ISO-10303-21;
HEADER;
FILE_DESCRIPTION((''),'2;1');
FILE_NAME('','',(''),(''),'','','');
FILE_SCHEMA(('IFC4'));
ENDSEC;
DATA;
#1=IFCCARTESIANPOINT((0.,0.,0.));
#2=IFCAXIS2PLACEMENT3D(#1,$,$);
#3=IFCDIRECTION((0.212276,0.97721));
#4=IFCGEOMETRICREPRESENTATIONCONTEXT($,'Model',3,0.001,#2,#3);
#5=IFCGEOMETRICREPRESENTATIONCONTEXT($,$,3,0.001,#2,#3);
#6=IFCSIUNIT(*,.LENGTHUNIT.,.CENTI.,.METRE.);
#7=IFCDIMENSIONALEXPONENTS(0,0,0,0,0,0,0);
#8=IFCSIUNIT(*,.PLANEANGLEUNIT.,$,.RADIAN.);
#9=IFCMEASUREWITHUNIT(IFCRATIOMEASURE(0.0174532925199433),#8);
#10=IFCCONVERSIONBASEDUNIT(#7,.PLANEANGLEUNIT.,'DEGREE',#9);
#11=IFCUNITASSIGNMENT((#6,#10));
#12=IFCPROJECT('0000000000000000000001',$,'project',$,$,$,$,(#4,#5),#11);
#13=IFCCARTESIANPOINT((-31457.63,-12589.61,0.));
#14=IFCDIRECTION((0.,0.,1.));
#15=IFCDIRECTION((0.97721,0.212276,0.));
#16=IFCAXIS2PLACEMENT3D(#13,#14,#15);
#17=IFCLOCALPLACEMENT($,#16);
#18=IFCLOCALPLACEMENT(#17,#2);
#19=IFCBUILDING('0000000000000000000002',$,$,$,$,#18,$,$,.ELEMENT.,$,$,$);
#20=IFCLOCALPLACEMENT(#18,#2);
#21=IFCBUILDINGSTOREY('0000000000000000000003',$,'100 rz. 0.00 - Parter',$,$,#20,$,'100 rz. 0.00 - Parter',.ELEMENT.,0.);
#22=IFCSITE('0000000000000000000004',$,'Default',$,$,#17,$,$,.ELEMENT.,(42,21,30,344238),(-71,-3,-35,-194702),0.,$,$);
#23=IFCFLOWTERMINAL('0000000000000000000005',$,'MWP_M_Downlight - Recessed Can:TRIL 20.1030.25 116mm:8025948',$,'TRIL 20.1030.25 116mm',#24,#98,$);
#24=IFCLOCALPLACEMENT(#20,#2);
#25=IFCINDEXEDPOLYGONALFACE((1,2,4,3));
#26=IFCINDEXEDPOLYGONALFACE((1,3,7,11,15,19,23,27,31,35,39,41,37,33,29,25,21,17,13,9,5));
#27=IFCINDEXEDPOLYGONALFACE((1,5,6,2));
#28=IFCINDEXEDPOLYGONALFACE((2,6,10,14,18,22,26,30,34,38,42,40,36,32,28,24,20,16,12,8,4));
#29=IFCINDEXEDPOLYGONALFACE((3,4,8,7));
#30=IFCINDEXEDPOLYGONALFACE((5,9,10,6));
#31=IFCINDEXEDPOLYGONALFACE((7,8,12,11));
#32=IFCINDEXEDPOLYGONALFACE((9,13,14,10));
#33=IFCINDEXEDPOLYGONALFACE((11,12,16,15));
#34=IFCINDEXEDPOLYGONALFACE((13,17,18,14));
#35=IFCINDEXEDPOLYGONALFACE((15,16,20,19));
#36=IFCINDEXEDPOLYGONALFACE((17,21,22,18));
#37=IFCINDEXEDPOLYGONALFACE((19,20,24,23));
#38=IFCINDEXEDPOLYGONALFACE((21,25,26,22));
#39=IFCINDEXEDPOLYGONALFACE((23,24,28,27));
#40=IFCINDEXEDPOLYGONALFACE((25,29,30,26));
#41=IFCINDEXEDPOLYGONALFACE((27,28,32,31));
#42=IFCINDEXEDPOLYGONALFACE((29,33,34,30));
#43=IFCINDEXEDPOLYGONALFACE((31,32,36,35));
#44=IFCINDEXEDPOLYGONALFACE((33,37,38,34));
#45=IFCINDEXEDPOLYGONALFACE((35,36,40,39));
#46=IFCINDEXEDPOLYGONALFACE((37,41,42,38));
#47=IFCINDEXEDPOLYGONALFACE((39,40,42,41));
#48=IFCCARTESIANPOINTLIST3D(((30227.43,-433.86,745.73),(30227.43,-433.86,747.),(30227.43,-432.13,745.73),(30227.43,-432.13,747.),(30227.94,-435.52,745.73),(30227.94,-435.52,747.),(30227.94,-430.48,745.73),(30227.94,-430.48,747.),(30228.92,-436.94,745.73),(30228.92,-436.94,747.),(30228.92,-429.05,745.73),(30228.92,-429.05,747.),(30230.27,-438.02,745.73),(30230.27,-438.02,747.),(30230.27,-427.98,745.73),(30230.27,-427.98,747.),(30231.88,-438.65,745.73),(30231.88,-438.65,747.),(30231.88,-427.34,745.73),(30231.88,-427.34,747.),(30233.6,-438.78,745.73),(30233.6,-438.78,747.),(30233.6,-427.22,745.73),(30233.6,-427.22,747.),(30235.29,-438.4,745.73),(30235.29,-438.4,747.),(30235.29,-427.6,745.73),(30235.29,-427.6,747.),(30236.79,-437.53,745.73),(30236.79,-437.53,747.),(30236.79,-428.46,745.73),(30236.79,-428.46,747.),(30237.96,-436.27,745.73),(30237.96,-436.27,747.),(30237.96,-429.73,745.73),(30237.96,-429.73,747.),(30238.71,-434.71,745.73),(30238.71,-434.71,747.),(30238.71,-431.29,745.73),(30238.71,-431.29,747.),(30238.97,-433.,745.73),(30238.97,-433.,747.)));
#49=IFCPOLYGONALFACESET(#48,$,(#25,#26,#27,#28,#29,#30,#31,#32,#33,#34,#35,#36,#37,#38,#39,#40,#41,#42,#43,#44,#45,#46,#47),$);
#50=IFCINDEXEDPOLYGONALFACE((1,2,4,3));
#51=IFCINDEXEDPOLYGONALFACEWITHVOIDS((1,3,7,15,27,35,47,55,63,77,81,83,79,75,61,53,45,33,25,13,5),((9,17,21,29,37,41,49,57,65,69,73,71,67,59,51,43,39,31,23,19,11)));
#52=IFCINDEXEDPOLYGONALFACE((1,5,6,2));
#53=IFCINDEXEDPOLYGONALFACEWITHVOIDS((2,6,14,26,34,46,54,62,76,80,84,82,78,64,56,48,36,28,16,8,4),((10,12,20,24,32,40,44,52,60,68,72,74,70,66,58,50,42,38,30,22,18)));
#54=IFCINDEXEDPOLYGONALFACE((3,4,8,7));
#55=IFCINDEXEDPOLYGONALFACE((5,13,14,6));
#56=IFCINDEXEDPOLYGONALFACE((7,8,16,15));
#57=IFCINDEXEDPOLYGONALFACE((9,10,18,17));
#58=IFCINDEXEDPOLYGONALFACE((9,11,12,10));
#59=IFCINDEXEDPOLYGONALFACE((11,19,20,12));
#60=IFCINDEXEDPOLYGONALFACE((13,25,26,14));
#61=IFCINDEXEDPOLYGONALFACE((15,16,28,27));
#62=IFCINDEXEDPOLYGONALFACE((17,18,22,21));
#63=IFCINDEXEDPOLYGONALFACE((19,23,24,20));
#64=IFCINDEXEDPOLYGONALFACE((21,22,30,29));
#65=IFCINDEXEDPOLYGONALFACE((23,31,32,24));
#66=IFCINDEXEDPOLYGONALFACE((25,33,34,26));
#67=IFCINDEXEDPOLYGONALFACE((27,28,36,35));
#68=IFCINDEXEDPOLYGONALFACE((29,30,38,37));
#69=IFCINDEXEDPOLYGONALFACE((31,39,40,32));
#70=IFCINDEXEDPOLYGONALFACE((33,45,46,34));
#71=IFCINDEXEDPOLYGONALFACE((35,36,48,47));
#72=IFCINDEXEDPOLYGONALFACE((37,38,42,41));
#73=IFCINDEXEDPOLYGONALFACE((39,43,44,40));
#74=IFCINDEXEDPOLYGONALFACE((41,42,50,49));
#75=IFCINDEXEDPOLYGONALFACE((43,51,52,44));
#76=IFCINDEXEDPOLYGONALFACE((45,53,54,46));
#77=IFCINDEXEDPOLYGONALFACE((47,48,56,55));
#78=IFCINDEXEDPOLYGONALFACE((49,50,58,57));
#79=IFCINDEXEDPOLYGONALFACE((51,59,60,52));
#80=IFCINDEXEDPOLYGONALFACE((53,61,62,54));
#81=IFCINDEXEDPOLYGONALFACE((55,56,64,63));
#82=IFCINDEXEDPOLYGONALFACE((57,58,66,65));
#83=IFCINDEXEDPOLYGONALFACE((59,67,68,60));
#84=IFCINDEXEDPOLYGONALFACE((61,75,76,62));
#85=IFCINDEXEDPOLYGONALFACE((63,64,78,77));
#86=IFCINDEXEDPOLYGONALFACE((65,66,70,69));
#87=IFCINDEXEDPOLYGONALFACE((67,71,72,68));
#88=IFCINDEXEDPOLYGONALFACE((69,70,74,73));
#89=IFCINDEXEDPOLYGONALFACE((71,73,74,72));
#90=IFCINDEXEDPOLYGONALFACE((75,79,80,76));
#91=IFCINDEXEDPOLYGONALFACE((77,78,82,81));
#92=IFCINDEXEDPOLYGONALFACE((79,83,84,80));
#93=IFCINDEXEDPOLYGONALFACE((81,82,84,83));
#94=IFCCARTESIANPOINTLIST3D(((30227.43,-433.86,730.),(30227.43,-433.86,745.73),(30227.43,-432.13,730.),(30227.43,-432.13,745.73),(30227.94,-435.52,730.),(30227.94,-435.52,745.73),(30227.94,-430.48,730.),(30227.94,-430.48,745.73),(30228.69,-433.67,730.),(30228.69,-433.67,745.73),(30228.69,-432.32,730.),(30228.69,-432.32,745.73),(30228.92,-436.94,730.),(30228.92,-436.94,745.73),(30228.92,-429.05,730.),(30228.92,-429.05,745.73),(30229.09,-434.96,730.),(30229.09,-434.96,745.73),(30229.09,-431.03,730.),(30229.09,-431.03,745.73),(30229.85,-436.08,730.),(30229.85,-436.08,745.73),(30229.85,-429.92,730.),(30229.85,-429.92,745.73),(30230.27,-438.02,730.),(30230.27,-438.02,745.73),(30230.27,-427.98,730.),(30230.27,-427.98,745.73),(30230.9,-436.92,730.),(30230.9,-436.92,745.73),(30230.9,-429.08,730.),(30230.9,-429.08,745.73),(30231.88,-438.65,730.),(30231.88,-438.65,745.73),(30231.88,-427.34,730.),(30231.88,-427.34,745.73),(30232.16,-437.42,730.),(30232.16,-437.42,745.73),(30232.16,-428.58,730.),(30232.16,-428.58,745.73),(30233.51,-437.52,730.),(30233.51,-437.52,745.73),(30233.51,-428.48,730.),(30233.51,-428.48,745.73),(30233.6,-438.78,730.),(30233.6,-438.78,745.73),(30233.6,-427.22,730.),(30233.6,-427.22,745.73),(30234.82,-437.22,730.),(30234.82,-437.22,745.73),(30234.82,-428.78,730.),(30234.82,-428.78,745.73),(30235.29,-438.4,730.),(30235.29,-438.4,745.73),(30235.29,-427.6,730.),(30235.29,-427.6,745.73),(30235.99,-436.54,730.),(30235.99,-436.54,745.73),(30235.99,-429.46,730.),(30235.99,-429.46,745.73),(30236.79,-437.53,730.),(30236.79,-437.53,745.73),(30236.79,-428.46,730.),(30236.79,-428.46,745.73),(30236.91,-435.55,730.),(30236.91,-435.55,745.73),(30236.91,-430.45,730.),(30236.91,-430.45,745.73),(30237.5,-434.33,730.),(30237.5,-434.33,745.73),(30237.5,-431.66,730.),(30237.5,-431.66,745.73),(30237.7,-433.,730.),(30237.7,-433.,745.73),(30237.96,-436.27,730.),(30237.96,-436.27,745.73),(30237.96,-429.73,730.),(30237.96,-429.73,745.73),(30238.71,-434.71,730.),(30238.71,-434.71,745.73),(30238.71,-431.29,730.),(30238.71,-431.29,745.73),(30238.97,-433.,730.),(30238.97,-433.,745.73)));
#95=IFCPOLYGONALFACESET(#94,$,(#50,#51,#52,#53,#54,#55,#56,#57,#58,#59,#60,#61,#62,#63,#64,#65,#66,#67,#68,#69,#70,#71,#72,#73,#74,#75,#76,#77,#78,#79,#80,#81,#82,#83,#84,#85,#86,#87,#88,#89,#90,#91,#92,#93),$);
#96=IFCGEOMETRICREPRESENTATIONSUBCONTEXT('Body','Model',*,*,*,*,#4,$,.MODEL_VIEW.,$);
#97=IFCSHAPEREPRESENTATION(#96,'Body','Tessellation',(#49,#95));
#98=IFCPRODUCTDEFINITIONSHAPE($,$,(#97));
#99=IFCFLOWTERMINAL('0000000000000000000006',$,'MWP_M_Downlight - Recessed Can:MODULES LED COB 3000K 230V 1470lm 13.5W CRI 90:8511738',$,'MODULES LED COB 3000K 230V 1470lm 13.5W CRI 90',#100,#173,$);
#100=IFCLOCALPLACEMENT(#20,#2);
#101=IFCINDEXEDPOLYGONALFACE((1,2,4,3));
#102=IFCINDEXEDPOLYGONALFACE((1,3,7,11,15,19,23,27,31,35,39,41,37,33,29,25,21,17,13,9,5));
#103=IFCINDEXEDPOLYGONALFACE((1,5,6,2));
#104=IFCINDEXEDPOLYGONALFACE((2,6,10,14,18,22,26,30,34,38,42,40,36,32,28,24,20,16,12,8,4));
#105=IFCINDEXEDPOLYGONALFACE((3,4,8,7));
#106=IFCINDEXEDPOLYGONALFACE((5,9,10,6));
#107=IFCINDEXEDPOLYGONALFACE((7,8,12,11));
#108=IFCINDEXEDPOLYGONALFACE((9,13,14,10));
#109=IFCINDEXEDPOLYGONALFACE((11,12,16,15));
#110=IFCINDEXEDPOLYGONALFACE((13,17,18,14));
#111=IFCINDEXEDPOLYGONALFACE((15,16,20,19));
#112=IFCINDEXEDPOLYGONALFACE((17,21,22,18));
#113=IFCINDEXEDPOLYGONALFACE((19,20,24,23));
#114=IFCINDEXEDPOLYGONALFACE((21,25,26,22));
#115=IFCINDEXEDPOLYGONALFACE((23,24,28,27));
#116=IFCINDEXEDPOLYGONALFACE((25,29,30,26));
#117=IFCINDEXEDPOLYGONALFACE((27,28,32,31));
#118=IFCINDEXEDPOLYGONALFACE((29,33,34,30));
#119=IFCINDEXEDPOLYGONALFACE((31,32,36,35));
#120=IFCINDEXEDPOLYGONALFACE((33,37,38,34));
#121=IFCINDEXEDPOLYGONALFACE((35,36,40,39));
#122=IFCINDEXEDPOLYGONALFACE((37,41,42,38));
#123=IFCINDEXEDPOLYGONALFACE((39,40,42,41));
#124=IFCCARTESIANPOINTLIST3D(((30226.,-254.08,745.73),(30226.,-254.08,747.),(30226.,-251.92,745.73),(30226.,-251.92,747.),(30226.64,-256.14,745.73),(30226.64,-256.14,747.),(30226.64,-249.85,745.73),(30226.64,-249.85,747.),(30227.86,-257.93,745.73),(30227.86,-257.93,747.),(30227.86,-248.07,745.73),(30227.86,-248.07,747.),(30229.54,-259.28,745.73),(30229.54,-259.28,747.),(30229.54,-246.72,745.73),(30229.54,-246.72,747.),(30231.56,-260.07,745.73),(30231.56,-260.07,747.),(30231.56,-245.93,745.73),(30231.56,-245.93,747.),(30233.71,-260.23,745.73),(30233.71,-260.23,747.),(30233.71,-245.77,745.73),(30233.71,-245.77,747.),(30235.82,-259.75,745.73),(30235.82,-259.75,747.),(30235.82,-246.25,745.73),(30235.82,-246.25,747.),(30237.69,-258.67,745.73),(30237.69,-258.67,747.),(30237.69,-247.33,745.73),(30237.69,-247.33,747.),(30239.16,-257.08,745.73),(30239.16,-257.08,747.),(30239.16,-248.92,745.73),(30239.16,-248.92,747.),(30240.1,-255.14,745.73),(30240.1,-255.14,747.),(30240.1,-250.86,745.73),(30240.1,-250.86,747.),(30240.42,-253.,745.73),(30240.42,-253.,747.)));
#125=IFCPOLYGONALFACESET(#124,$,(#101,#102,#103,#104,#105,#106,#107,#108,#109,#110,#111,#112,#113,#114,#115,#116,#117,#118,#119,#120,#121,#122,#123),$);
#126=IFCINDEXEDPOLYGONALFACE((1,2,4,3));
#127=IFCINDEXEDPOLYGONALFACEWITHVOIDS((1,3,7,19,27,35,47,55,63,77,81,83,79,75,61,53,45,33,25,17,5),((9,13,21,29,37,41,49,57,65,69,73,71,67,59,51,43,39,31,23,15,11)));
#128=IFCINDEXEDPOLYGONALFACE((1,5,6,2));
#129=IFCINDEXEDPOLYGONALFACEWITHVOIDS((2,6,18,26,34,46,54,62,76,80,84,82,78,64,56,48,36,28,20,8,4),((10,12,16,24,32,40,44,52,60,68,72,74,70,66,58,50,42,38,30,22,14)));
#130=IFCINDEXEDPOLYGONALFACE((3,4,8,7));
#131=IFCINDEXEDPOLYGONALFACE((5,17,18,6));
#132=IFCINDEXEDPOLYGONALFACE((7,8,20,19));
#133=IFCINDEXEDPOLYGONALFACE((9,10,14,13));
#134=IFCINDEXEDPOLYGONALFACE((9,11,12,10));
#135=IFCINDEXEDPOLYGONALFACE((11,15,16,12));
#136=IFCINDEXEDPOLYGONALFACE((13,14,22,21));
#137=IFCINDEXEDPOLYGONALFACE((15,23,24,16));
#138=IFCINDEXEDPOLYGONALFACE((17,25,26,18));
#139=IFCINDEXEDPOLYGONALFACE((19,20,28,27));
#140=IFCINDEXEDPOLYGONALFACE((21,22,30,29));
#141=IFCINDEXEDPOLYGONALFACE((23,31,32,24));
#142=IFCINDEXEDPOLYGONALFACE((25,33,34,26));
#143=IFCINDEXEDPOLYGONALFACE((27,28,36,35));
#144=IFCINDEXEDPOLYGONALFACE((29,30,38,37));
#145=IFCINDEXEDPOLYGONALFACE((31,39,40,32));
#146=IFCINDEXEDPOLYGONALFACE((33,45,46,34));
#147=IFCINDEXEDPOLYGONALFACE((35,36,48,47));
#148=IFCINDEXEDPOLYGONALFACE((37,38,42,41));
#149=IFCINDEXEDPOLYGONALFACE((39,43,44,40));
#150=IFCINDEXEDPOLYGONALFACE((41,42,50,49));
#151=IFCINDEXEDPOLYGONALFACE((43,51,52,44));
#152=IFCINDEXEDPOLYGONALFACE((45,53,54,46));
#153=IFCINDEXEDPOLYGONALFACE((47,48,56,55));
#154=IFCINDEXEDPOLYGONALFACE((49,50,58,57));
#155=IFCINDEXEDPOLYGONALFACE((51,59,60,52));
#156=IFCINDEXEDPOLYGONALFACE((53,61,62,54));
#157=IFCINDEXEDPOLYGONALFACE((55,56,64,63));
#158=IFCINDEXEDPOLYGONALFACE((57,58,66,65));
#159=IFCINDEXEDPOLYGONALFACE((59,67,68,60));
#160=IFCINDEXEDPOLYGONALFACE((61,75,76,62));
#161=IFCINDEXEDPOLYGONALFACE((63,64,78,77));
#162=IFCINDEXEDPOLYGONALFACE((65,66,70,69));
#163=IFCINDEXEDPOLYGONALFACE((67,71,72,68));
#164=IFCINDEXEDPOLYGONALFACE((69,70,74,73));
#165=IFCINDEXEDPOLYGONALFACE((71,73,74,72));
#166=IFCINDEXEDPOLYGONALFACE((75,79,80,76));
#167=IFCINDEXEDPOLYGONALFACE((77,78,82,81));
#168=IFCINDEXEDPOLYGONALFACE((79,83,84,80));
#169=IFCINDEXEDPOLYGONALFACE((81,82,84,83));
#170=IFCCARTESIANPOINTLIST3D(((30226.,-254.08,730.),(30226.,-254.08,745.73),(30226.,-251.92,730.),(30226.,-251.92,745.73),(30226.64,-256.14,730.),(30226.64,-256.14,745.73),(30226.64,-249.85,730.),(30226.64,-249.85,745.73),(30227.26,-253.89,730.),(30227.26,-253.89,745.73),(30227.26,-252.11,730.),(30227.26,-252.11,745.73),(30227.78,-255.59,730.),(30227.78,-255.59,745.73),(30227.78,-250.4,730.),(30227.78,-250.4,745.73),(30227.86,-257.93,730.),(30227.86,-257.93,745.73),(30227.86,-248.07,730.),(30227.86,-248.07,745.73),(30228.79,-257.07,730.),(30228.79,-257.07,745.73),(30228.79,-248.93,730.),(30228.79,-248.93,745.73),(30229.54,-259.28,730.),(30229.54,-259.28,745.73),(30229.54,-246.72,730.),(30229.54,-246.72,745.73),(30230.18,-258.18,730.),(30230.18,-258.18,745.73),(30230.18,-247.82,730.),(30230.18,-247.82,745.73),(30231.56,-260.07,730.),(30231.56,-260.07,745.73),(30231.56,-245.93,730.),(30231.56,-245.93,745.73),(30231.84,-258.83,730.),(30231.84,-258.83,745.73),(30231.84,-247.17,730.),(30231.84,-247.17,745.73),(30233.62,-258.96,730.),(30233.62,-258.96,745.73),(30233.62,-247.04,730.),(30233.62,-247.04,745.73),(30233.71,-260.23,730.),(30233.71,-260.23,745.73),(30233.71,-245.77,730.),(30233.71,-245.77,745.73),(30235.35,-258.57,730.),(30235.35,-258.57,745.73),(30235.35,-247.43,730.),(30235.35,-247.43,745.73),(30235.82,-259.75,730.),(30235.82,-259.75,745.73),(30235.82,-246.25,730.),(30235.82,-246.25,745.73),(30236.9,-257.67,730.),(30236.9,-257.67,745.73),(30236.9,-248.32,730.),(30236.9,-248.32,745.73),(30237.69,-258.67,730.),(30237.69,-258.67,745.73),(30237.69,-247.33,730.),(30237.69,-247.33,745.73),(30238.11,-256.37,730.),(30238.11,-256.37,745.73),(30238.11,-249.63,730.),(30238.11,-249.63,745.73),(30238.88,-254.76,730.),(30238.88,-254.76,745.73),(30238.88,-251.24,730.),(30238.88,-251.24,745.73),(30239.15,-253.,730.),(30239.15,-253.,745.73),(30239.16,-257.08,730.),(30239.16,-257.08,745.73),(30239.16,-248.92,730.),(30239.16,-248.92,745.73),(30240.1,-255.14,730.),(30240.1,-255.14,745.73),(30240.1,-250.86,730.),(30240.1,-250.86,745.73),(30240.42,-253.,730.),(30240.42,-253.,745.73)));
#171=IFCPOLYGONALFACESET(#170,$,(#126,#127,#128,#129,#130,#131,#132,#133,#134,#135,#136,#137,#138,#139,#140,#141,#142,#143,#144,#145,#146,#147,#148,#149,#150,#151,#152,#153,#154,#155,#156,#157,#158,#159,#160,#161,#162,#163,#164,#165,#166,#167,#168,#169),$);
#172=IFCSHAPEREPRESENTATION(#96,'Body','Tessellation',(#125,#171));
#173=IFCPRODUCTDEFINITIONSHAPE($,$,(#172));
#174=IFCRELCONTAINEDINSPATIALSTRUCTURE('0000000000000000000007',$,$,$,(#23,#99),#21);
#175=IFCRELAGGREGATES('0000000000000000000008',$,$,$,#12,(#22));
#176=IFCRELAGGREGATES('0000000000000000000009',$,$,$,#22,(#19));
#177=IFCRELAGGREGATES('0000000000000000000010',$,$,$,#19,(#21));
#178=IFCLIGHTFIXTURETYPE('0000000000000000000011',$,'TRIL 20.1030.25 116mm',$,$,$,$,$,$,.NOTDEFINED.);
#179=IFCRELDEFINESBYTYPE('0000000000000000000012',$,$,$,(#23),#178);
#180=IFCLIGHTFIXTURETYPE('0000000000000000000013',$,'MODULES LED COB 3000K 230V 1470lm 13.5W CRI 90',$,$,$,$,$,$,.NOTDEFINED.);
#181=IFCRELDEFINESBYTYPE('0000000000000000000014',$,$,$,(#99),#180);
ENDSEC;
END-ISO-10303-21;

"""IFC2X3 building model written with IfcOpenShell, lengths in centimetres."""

from ifc_helpers import new_model, entity, si_unit, converted_unit, direction, frame, frame_2d, origin, place, context, subcontext, project, spatial, circle, hollow_circle, extrude, source, transform, mapped, type_object, type_shapes, element, save


model = new_model("IFC2X3")

# Units and contexts
model_context = context("Model", 3, precision=0.001, world=origin(), true_north=direction((0.212276, 0.97721)))
context_of_model = context(None, 3, precision=0.001, world=origin(), true_north=direction((0.212276, 0.97721)))
body_context = subcontext(model_context, "Body", "Model", "MODEL_VIEW")
ifc_project = project(units=[si_unit("LENGTHUNIT", "METRE", prefix="CENTI"), converted_unit("PLANEANGLEUNIT", "DEGREE", entity("IfcRatioMeasure", 0.0174532925199433), si_unit("PLANEANGLEUNIT", "RADIAN"), dimensions=[0, 0, 0, 0, 0, 0, 0])], contexts=[model_context, context_of_model])

# Site, building, storey
site_placement = place(None, frame((-31457.63, -12589.61, 0.0), z_axis=(0.0, 0.0, 1.0), x_axis=(0.97721, 0.212276, 0.0)))
site = spatial("IfcSite", under=ifc_project, at=site_placement, Name="Default", CompositionType="ELEMENT", RefLatitude=(42, 21, 30, 344238), RefLongitude=(-71, -3, -35, -194702), RefElevation=0.0)
building_placement = place(site_placement, origin())
building = spatial("IfcBuilding", under=site, at=building_placement, CompositionType="ELEMENT")
storey_placement = place(building_placement, origin())
storey = spatial("IfcBuildingStorey", under=building, at=storey_placement, Name="100 rz. 0.00 - Parter", LongName="100 rz. 0.00 - Parter", CompositionType="ELEMENT", Elevation=0.0)

# Flow terminals
light_fixture_type_1 = type_object("IfcLightFixtureType", Name="TRIL 20.1030.25 116mm", PredefinedType="NOTDEFINED")
shared_shape_1 = source(origin(), body_context, "Body", "SweptSolid", [
    extrude(circle(Radius=5.8, at=frame_2d((0.0, 0.0), x_axis=(1.0, 0.0))), frame((5.96, 5.81, 15.73)), (0.0, 0.0, 1.0), 1.27),
    extrude(hollow_circle(Radius=5.8, WallThickness=1.27, at=frame_2d((0.0, 0.0), x_axis=(1.0, 0.0))), frame((5.96, 5.81, 0.0)), (0.0, 0.0, 1.0), 15.73),
])
type_shapes(light_fixture_type_1, [shared_shape_1])
for number, where, name in (
    (1, (30227.21, -438.81, 730.0), "MWP_M_Downlight - Recessed Can:TRIL 20.1030.25 116mm:8025948"),
):
    element("IfcFlowTerminal", number, at=place(storey_placement, frame(where)), inside=storey, type_object=light_fixture_type_1, Name=name, ObjectType="TRIL 20.1030.25 116mm", context=body_context, shape_type="MappedRepresentation", body=[
        mapped(shared_shape_1, transform((0.0, 0.0, 0.0), scale=1.0)),
    ])
light_fixture_type_2 = type_object("IfcLightFixtureType", Name="MODULES LED COB 3000K 230V 1470lm 13.5W CRI 90", PredefinedType="NOTDEFINED")
shared_shape_2 = source(origin(), body_context, "Body", "SweptSolid", [
    extrude(circle(Radius=7.25, at=frame_2d((0.0, 0.0), x_axis=(1.0, 0.0))), frame((7.41, 7.41, 15.73)), (0.0, 0.0, 1.0), 1.27),
    extrude(hollow_circle(Radius=7.25, WallThickness=1.27, at=frame_2d((0.0, 0.0), x_axis=(1.0, 0.0))), frame((7.41, 7.41, 0.0)), (0.0, 0.0, 1.0), 15.73),
])
type_shapes(light_fixture_type_2, [shared_shape_2])
for number, where, name in (
    (2, (30225.76, -260.41, 730.0), "MWP_M_Downlight - Recessed Can:MODULES LED COB 3000K 230V 1470lm 13.5W CRI 90:8511738"),
):
    element("IfcFlowTerminal", number, at=place(storey_placement, frame(where)), inside=storey, type_object=light_fixture_type_2, Name=name, ObjectType="MODULES LED COB 3000K 230V 1470lm 13.5W CRI 90", context=body_context, shape_type="MappedRepresentation", body=[
        mapped(shared_shape_2, transform((0.0, 0.0, 0.0), scale=1.0)),
    ])

save(model, "model.ifc")
